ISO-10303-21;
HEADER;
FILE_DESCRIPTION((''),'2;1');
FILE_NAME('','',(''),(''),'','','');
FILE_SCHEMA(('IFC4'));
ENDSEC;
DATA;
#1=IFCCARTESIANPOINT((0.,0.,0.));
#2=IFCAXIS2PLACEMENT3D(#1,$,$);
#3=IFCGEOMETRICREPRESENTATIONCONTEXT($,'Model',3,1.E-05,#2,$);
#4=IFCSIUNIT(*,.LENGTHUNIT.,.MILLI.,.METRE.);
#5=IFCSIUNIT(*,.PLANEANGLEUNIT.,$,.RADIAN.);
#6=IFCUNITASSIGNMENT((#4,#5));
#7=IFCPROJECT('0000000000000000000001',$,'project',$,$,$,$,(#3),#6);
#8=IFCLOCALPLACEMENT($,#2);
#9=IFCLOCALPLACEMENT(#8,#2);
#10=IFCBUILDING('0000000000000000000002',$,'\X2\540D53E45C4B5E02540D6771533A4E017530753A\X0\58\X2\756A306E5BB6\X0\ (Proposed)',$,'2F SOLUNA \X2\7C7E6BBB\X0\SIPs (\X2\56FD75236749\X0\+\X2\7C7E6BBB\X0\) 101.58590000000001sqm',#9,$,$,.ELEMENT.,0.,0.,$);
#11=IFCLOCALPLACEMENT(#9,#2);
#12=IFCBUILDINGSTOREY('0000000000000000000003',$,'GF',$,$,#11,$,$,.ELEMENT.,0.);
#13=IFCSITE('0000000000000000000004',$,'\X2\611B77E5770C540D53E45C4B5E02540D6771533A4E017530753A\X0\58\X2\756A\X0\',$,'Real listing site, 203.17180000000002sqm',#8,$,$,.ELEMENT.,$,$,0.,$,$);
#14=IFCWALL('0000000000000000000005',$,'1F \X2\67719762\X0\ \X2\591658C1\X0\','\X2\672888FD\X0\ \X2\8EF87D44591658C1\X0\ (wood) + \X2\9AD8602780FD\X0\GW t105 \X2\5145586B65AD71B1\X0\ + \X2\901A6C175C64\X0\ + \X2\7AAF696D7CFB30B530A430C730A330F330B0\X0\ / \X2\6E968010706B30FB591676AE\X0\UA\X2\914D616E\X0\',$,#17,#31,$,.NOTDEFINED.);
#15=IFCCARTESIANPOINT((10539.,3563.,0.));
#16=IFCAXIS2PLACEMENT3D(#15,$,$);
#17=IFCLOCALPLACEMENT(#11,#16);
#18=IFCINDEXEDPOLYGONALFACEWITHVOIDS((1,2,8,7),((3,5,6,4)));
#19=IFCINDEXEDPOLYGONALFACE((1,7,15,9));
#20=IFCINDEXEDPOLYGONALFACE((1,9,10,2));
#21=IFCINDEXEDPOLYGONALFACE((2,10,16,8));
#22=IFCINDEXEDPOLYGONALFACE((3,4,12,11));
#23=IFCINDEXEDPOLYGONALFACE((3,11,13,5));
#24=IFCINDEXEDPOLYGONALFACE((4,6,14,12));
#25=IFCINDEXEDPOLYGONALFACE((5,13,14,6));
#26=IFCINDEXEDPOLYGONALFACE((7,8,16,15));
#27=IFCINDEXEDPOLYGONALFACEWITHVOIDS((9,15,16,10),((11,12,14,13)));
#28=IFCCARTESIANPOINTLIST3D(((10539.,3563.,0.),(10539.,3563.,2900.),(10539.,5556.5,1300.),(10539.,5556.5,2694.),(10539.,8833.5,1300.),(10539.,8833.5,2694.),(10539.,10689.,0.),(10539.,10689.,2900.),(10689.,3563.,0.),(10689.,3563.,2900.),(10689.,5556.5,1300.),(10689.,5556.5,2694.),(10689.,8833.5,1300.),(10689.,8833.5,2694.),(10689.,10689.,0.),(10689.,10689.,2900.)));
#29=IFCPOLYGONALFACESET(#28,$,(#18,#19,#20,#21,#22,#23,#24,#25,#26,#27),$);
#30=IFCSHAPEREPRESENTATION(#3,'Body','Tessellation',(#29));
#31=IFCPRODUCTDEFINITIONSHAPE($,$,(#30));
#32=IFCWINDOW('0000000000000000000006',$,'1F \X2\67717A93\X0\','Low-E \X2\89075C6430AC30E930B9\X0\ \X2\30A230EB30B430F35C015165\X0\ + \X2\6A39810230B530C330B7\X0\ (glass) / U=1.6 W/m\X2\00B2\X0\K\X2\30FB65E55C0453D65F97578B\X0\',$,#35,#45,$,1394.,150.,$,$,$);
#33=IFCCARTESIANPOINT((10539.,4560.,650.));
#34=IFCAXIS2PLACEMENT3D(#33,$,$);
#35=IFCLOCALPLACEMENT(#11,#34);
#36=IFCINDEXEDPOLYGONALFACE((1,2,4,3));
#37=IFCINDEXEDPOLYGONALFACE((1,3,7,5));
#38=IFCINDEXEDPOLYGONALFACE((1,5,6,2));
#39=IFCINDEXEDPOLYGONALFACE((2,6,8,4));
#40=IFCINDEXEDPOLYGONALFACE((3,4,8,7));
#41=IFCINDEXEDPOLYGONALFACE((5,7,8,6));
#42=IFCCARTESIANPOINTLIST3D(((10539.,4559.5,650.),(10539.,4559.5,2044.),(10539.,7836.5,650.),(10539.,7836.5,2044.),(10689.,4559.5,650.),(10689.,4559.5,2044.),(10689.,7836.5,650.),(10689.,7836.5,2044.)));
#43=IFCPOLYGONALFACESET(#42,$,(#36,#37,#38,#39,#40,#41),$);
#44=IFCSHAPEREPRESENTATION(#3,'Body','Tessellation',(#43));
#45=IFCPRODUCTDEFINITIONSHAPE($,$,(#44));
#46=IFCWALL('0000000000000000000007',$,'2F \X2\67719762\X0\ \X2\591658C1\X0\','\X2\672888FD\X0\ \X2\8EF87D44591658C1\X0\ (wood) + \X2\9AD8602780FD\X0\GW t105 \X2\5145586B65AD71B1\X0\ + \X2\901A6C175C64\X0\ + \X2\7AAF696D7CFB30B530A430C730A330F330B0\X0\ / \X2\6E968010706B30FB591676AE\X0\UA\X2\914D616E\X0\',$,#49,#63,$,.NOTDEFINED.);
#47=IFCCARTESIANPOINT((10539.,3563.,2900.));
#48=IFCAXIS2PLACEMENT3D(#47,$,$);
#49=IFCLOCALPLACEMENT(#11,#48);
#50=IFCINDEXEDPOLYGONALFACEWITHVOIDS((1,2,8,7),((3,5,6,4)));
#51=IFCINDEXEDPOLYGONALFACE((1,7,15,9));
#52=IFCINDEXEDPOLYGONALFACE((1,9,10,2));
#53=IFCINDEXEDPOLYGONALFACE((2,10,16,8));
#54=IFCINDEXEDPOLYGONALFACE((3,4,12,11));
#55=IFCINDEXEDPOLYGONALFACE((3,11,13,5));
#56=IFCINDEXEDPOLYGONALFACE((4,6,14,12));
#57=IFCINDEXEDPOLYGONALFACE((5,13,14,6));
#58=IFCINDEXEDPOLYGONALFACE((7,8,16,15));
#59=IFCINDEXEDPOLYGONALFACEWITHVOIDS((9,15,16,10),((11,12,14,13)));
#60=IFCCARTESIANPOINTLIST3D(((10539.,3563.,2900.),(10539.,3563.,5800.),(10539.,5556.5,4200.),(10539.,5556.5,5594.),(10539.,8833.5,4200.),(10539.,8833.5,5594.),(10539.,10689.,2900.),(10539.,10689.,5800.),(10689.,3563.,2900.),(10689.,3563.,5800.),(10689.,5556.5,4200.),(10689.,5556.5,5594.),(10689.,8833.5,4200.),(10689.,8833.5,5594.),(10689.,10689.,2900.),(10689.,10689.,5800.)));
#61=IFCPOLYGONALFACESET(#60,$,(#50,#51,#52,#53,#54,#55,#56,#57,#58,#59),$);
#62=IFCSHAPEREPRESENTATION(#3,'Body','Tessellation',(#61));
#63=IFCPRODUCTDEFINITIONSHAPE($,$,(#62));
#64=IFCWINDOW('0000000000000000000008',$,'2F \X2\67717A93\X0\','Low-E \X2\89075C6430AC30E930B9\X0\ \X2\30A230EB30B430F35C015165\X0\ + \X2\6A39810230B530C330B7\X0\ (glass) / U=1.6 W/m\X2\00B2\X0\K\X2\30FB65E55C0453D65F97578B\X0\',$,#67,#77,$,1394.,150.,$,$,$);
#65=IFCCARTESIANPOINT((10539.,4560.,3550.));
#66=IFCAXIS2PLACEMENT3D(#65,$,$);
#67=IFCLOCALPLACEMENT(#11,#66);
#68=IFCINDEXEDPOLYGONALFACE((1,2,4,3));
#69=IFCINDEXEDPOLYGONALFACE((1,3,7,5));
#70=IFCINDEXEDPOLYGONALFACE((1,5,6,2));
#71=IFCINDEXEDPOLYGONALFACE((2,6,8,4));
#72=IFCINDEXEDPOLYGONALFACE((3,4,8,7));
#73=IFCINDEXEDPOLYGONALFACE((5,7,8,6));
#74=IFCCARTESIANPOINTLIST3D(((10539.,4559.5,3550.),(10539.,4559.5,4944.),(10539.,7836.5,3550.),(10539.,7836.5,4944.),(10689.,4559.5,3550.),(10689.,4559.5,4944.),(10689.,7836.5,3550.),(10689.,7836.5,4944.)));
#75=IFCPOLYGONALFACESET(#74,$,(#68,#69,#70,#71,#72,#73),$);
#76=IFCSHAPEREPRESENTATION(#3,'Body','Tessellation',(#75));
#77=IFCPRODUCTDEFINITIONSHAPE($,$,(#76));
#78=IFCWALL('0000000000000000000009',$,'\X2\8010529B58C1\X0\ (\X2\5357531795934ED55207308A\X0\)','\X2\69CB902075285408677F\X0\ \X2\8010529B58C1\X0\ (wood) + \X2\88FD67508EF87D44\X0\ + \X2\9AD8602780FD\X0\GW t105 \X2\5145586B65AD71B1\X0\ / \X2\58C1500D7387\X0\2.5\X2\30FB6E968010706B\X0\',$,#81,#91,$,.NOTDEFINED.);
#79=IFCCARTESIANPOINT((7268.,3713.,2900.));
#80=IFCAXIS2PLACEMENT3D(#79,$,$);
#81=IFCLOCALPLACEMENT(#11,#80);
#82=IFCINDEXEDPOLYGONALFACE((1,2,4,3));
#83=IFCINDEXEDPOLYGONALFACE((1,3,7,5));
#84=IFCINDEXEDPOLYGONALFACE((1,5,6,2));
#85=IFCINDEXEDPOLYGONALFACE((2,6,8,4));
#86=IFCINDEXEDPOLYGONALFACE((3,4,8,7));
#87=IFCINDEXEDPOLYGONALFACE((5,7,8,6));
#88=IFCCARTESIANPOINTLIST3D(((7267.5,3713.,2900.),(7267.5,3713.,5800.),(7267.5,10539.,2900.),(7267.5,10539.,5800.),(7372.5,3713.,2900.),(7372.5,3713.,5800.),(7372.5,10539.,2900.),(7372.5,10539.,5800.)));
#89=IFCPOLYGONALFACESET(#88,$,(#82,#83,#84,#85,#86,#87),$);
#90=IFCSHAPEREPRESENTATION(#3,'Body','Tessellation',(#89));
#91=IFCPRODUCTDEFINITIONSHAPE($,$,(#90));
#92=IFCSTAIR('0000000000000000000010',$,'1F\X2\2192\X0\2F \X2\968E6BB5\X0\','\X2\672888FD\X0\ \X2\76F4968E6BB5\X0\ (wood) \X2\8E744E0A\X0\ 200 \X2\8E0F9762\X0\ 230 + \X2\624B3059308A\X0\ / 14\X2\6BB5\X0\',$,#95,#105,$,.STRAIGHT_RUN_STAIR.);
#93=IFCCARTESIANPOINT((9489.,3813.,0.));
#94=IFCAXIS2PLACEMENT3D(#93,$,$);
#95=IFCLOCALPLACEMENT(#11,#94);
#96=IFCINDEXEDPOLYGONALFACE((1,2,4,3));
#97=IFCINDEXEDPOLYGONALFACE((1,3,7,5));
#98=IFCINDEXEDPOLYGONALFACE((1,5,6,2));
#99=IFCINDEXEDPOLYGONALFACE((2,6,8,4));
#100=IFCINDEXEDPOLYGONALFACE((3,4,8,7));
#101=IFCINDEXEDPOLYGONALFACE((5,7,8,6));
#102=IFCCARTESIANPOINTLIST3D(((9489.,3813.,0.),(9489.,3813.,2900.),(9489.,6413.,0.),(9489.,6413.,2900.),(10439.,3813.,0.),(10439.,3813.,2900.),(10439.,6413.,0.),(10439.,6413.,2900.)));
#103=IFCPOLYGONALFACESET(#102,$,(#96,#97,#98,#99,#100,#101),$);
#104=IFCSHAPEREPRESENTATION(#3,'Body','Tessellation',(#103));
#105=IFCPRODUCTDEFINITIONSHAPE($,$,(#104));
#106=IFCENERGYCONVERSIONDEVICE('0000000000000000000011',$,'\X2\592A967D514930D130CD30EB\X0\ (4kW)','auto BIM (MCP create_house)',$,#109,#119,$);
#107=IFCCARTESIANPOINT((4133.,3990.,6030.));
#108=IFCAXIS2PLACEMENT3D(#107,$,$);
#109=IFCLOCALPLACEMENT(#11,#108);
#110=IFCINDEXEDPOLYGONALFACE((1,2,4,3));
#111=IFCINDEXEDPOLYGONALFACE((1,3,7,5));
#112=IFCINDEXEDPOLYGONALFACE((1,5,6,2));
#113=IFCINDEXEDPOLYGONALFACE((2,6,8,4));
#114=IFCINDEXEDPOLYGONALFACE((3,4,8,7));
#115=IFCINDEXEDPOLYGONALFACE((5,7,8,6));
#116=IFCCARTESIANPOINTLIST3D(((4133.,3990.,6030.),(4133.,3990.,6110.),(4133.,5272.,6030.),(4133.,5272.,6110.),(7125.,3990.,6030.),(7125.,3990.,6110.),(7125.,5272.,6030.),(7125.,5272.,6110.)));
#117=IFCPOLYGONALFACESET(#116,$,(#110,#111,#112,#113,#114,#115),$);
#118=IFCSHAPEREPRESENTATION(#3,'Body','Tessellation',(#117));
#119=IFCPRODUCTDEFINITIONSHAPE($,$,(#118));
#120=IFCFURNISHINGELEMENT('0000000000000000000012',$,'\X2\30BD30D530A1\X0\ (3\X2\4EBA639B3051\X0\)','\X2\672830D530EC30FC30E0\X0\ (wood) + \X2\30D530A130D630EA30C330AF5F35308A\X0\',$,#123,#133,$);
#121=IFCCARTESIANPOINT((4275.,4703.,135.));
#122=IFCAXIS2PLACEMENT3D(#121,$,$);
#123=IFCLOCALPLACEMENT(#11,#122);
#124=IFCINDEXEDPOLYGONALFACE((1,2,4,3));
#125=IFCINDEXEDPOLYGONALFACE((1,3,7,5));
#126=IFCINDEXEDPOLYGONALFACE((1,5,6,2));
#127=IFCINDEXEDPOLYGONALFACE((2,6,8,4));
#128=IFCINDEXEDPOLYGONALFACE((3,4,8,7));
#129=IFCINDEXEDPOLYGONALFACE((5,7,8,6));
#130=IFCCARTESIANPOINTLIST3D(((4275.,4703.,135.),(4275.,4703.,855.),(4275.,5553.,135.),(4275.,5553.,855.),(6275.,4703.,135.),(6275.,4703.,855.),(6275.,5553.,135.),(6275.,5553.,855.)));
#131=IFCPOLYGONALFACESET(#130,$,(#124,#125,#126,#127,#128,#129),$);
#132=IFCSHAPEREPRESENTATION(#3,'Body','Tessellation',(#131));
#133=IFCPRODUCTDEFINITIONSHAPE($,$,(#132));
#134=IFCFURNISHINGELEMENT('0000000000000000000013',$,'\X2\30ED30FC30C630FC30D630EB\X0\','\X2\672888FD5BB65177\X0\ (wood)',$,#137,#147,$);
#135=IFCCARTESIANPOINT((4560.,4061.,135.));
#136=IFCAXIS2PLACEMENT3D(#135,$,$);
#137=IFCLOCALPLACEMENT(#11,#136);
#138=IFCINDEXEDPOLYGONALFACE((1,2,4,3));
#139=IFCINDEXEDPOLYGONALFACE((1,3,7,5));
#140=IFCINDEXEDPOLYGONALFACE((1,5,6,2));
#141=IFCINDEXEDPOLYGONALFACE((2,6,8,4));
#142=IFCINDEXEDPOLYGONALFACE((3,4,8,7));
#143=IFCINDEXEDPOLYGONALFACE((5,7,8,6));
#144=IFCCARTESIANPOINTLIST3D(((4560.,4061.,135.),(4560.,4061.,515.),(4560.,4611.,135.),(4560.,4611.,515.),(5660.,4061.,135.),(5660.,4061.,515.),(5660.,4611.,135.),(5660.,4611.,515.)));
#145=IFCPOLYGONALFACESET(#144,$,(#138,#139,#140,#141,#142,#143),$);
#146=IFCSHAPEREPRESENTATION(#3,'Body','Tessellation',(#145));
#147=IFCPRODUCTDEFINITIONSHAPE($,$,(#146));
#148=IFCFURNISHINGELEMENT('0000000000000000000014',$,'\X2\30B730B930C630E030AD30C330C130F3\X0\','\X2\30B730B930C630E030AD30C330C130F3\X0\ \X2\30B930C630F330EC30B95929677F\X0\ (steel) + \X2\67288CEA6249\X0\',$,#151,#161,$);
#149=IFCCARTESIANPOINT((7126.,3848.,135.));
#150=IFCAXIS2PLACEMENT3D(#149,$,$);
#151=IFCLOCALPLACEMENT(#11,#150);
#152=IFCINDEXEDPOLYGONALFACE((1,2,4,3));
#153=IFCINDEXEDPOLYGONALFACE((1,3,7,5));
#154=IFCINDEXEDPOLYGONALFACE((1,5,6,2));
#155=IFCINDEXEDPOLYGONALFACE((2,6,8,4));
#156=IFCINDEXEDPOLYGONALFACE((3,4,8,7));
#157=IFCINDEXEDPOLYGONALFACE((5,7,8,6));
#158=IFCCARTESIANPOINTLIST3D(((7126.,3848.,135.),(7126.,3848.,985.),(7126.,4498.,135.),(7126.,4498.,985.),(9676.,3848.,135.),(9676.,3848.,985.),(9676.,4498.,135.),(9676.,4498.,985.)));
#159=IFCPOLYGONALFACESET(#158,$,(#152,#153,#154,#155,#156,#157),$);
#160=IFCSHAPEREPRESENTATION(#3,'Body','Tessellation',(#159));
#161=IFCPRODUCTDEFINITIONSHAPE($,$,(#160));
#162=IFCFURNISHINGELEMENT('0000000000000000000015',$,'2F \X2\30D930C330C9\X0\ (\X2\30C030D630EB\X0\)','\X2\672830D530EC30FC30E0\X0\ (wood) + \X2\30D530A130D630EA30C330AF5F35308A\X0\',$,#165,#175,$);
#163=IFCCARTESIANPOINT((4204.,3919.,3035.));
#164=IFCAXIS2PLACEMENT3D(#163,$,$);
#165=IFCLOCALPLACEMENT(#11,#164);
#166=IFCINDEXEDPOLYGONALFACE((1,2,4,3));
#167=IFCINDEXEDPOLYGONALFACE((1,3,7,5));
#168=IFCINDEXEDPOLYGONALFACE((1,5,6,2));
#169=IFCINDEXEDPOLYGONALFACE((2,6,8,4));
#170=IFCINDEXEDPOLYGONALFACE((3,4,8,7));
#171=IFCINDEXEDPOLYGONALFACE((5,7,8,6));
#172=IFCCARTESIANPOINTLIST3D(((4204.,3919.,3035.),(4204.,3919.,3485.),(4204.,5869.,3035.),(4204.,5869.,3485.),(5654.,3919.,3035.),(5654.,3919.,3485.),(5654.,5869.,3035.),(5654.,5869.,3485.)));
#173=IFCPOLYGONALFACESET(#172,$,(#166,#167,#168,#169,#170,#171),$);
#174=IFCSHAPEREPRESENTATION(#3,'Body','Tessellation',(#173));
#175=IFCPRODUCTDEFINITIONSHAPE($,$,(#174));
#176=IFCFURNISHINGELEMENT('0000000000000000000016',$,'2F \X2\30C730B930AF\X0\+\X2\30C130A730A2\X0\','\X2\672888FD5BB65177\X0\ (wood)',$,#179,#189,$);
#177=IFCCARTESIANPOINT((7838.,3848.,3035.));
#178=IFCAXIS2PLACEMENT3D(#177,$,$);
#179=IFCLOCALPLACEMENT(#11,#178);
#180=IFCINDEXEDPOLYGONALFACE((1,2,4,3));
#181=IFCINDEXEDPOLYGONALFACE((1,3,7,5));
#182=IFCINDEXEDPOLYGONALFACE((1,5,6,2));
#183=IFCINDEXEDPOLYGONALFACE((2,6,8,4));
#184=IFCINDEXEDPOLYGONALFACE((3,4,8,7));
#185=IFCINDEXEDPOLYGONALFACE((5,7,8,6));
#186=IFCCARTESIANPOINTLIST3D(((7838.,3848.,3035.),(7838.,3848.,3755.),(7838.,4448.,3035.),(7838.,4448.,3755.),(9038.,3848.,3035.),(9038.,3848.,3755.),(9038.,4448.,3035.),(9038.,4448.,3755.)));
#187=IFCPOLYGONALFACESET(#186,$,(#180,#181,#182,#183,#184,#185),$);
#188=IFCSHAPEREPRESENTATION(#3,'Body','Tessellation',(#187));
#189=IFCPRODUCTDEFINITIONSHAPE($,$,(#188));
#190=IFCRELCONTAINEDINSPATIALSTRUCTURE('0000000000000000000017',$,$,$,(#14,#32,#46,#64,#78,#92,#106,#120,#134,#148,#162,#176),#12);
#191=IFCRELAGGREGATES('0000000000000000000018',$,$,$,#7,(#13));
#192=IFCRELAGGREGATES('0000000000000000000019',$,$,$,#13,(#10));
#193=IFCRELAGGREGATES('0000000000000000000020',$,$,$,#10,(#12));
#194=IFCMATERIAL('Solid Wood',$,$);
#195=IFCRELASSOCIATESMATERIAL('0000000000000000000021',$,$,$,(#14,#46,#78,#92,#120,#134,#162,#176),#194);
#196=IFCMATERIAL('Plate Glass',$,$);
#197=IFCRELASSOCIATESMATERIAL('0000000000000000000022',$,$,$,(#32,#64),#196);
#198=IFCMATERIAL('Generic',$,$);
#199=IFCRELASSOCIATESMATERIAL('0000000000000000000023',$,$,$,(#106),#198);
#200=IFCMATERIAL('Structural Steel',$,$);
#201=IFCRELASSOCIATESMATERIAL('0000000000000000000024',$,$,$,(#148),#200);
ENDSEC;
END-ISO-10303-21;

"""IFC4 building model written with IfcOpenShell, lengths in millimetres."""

from ifc_helpers import new_model, si_unit, frame, frame_2d, origin, place, context, project, spatial, rectangle, extrude, material, element, fill, save


model = new_model("IFC4")

# Units and contexts
model_context = context("Model", 3, precision=1e-05, world=origin())
ifc_project = project(units=[si_unit("LENGTHUNIT", "METRE", prefix="MILLI"), si_unit("PLANEANGLEUNIT", "RADIAN")], contexts=[model_context])

# Site, building, storey
site_placement = place(None, origin())
site = spatial("IfcSite", under=ifc_project, at=site_placement, Name="愛知県名古屋市名東区丁田町58番", ObjectType="Real listing site, 203.17180000000002sqm", CompositionType="ELEMENT", RefElevation=0.0)
building_placement = place(site_placement, origin())
building = spatial("IfcBuilding", under=site, at=building_placement, Name="名古屋市名東区丁田町58番の家 (Proposed)", ObjectType="2F SOLUNA 籾殻SIPs (国産杉+籾殻) 101.58590000000001sqm", CompositionType="ELEMENT", ElevationOfRefHeight=0.0, ElevationOfTerrain=0.0)
storey_placement = place(building_placement, origin())
storey = spatial("IfcBuildingStorey", under=building, at=storey_placement, Name="GF", CompositionType="ELEMENT", Elevation=0.0)

# Wall, opening, window
ifc_material_1 = material(Name="Solid Wood")
wall_1_placement = place(storey_placement, frame((10539.0, 3563.0, 0.0)))
wall_1 = element("IfcWall", 1, at=wall_1_placement, inside=storey, material=ifc_material_1, Name="1F 東面 外壁", Description="木製 軸組外壁 (wood) + 高性能GW t105 充填断熱 + 通気層 + 窯業系サイディング / 準耐火・外皮UA配慮", PredefinedType="NOTDEFINED", context=model_context, shape_type="SweptSolid", body=[
    extrude(rectangle(XDim=150.0, YDim=7126.0, at=frame_2d((75.0, 3563.0))), frame((10539.0, 3563.0, 0.0)), (0.0, 0.0, 1.0), 2900.0),
])
opening_1_placement = place(storey_placement, frame((10539.0, 4560.0, 650.0)))
opening_1 = element("IfcOpeningElement", 2, at=opening_1_placement, cuts=wall_1, PredefinedType="NOTDEFINED", context=model_context, shape_type="SweptSolid", body=[
    extrude(rectangle(XDim=150.0, YDim=3277.0, at=frame_2d((75.0, 1638.0))), frame((10539.0, 4560.0, 650.0)), (0.0, 0.0, 1.0), 1394.0),
])
ifc_material_2 = material(Name="Plate Glass")
window_1_placement = place(storey_placement, frame((10539.0, 4560.0, 650.0)))
window_1 = element("IfcWindow", 3, at=window_1_placement, inside=storey, material=ifc_material_2, Name="1F 東窓", Description="Low-E 複層ガラス アルゴン封入 + 樹脂サッシ (glass) / U=1.6 W/m²K・日射取得型", OverallHeight=1394.0, OverallWidth=150.0, context=model_context, shape_type="SweptSolid", body=[
    extrude(rectangle(XDim=150.0, YDim=3277.0, at=frame_2d((75.0, 1638.0))), frame((10539.0, 4560.0, 650.0)), (0.0, 0.0, 1.0), 1394.0),
])
fill(opening_1, window_1)

# Wall, opening, window
wall_2_placement = place(storey_placement, frame((10539.0, 3563.0, 2900.0)))
wall_2 = element("IfcWall", 4, at=wall_2_placement, inside=storey, material=ifc_material_1, Name="2F 東面 外壁", Description="木製 軸組外壁 (wood) + 高性能GW t105 充填断熱 + 通気層 + 窯業系サイディング / 準耐火・外皮UA配慮", PredefinedType="NOTDEFINED", context=model_context, shape_type="SweptSolid", body=[
    extrude(rectangle(XDim=150.0, YDim=7126.0, at=frame_2d((75.0, 3563.0))), frame((10539.0, 3563.0, 2900.0)), (0.0, 0.0, 1.0), 2900.0),
])
opening_2_placement = place(storey_placement, frame((10539.0, 4560.0, 3550.0)))
opening_2 = element("IfcOpeningElement", 5, at=opening_2_placement, cuts=wall_2, PredefinedType="NOTDEFINED", context=model_context, shape_type="SweptSolid", body=[
    extrude(rectangle(XDim=150.0, YDim=3277.0, at=frame_2d((75.0, 1638.0))), frame((10539.0, 4560.0, 3550.0)), (0.0, 0.0, 1.0), 1394.0),
])
window_2_placement = place(storey_placement, frame((10539.0, 4560.0, 3550.0)))
window_2 = element("IfcWindow", 6, at=window_2_placement, inside=storey, material=ifc_material_2, Name="2F 東窓", Description="Low-E 複層ガラス アルゴン封入 + 樹脂サッシ (glass) / U=1.6 W/m²K・日射取得型", OverallHeight=1394.0, OverallWidth=150.0, context=model_context, shape_type="SweptSolid", body=[
    extrude(rectangle(XDim=150.0, YDim=3277.0, at=frame_2d((75.0, 1638.0))), frame((10539.0, 4560.0, 3550.0)), (0.0, 0.0, 1.0), 1394.0),
])
fill(opening_2, window_2)

# Wall
wall_3_placement = place(storey_placement, frame((7268.0, 3713.0, 2900.0)))
element("IfcWall", 7, at=wall_3_placement, inside=storey, material=ifc_material_1, Name="耐力壁 (南北間仕切り)", Description="構造用合板 耐力壁 (wood) + 製材軸組 + 高性能GW t105 充填断熱 / 壁倍率2.5・準耐火", PredefinedType="NOTDEFINED", context=model_context, shape_type="SweptSolid", body=[
    extrude(rectangle(XDim=105.0, YDim=6826.0, at=frame_2d((52.0, 3413.0))), frame((7268.0, 3713.0, 2900.0)), (0.0, 0.0, 1.0), 2900.0),
])

# Stair
stair_placement = place(storey_placement, frame((9489.0, 3813.0, 0.0)))
element("IfcStair", 8, at=stair_placement, inside=storey, material=ifc_material_1, Name="1F→2F 階段", Description="木製 直階段 (wood) 蹴上 200 踏面 230 + 手すり / 14段", PredefinedType="STRAIGHT_RUN_STAIR", context=model_context, shape_type="SweptSolid", body=[
    extrude(rectangle(XDim=950.0, YDim=2600.0, at=frame_2d((475.0, 1300.0))), frame((9489.0, 3813.0, 0.0)), (0.0, 0.0, 1.0), 2900.0),
])

# Energy conversion device
ifc_material_3 = material(Name="Generic")
energy_conversion_device_placement = place(storey_placement, frame((4133.0, 3990.0, 6030.0)))
element("IfcEnergyConversionDevice", 9, at=energy_conversion_device_placement, inside=storey, material=ifc_material_3, Name="太陽光パネル (4kW)", Description="auto BIM (MCP create_house)", context=model_context, shape_type="SweptSolid", body=[
    extrude(rectangle(XDim=2992.0, YDim=1282.0, at=frame_2d((1496.0, 641.0))), frame((4133.0, 3990.0, 6030.0)), (0.0, 0.0, 1.0), 80.0),
])

# Furnishing elements
furnishing_1_placement = place(storey_placement, frame((4275.0, 4703.0, 135.0)))
element("IfcFurnishingElement", 10, at=furnishing_1_placement, inside=storey, material=ifc_material_1, Name="ソファ (3人掛け)", Description="木フレーム (wood) + ファブリック張り", context=model_context, shape_type="SweptSolid", body=[
    extrude(rectangle(XDim=2000.0, YDim=850.0, at=frame_2d((1000.0, 425.0))), frame((4275.0, 4703.0, 135.0)), (0.0, 0.0, 1.0), 720.0),
])
furnishing_2_placement = place(storey_placement, frame((4560.0, 4061.0, 135.0)))
element("IfcFurnishingElement", 11, at=furnishing_2_placement, inside=storey, material=ifc_material_1, Name="ローテーブル", Description="木製家具 (wood)", context=model_context, shape_type="SweptSolid", body=[
    extrude(rectangle(XDim=1100.0, YDim=550.0, at=frame_2d((550.0, 275.0))), frame((4560.0, 4061.0, 135.0)), (0.0, 0.0, 1.0), 380.0),
])
ifc_material_4 = material(Name="Structural Steel")
furnishing_3_placement = place(storey_placement, frame((7126.0, 3848.0, 135.0)))
element("IfcFurnishingElement", 12, at=furnishing_3_placement, inside=storey, material=ifc_material_4, Name="システムキッチン", Description="システムキッチン ステンレス天板 (steel) + 木質扉", context=model_context, shape_type="SweptSolid", body=[
    extrude(rectangle(XDim=2550.0, YDim=650.0, at=frame_2d((1275.0, 325.0))), frame((7126.0, 3848.0, 135.0)), (0.0, 0.0, 1.0), 850.0),
])
furnishing_4_placement = place(storey_placement, frame((4204.0, 3919.0, 3035.0)))
element("IfcFurnishingElement", 13, at=furnishing_4_placement, inside=storey, material=ifc_material_1, Name="2F ベッド (ダブル)", Description="木フレーム (wood) + ファブリック張り", context=model_context, shape_type="SweptSolid", body=[
    extrude(rectangle(XDim=1450.0, YDim=1950.0, at=frame_2d((725.0, 975.0))), frame((4204.0, 3919.0, 3035.0)), (0.0, 0.0, 1.0), 450.0),
])
furnishing_5_placement = place(storey_placement, frame((7838.0, 3848.0, 3035.0)))
element("IfcFurnishingElement", 14, at=furnishing_5_placement, inside=storey, material=ifc_material_1, Name="2F デスク+チェア", Description="木製家具 (wood)", context=model_context, shape_type="SweptSolid", body=[
    extrude(rectangle(XDim=1200.0, YDim=600.0, at=frame_2d((600.0, 300.0))), frame((7838.0, 3848.0, 3035.0)), (0.0, 0.0, 1.0), 720.0),
])

save(model, "model.ifc")
